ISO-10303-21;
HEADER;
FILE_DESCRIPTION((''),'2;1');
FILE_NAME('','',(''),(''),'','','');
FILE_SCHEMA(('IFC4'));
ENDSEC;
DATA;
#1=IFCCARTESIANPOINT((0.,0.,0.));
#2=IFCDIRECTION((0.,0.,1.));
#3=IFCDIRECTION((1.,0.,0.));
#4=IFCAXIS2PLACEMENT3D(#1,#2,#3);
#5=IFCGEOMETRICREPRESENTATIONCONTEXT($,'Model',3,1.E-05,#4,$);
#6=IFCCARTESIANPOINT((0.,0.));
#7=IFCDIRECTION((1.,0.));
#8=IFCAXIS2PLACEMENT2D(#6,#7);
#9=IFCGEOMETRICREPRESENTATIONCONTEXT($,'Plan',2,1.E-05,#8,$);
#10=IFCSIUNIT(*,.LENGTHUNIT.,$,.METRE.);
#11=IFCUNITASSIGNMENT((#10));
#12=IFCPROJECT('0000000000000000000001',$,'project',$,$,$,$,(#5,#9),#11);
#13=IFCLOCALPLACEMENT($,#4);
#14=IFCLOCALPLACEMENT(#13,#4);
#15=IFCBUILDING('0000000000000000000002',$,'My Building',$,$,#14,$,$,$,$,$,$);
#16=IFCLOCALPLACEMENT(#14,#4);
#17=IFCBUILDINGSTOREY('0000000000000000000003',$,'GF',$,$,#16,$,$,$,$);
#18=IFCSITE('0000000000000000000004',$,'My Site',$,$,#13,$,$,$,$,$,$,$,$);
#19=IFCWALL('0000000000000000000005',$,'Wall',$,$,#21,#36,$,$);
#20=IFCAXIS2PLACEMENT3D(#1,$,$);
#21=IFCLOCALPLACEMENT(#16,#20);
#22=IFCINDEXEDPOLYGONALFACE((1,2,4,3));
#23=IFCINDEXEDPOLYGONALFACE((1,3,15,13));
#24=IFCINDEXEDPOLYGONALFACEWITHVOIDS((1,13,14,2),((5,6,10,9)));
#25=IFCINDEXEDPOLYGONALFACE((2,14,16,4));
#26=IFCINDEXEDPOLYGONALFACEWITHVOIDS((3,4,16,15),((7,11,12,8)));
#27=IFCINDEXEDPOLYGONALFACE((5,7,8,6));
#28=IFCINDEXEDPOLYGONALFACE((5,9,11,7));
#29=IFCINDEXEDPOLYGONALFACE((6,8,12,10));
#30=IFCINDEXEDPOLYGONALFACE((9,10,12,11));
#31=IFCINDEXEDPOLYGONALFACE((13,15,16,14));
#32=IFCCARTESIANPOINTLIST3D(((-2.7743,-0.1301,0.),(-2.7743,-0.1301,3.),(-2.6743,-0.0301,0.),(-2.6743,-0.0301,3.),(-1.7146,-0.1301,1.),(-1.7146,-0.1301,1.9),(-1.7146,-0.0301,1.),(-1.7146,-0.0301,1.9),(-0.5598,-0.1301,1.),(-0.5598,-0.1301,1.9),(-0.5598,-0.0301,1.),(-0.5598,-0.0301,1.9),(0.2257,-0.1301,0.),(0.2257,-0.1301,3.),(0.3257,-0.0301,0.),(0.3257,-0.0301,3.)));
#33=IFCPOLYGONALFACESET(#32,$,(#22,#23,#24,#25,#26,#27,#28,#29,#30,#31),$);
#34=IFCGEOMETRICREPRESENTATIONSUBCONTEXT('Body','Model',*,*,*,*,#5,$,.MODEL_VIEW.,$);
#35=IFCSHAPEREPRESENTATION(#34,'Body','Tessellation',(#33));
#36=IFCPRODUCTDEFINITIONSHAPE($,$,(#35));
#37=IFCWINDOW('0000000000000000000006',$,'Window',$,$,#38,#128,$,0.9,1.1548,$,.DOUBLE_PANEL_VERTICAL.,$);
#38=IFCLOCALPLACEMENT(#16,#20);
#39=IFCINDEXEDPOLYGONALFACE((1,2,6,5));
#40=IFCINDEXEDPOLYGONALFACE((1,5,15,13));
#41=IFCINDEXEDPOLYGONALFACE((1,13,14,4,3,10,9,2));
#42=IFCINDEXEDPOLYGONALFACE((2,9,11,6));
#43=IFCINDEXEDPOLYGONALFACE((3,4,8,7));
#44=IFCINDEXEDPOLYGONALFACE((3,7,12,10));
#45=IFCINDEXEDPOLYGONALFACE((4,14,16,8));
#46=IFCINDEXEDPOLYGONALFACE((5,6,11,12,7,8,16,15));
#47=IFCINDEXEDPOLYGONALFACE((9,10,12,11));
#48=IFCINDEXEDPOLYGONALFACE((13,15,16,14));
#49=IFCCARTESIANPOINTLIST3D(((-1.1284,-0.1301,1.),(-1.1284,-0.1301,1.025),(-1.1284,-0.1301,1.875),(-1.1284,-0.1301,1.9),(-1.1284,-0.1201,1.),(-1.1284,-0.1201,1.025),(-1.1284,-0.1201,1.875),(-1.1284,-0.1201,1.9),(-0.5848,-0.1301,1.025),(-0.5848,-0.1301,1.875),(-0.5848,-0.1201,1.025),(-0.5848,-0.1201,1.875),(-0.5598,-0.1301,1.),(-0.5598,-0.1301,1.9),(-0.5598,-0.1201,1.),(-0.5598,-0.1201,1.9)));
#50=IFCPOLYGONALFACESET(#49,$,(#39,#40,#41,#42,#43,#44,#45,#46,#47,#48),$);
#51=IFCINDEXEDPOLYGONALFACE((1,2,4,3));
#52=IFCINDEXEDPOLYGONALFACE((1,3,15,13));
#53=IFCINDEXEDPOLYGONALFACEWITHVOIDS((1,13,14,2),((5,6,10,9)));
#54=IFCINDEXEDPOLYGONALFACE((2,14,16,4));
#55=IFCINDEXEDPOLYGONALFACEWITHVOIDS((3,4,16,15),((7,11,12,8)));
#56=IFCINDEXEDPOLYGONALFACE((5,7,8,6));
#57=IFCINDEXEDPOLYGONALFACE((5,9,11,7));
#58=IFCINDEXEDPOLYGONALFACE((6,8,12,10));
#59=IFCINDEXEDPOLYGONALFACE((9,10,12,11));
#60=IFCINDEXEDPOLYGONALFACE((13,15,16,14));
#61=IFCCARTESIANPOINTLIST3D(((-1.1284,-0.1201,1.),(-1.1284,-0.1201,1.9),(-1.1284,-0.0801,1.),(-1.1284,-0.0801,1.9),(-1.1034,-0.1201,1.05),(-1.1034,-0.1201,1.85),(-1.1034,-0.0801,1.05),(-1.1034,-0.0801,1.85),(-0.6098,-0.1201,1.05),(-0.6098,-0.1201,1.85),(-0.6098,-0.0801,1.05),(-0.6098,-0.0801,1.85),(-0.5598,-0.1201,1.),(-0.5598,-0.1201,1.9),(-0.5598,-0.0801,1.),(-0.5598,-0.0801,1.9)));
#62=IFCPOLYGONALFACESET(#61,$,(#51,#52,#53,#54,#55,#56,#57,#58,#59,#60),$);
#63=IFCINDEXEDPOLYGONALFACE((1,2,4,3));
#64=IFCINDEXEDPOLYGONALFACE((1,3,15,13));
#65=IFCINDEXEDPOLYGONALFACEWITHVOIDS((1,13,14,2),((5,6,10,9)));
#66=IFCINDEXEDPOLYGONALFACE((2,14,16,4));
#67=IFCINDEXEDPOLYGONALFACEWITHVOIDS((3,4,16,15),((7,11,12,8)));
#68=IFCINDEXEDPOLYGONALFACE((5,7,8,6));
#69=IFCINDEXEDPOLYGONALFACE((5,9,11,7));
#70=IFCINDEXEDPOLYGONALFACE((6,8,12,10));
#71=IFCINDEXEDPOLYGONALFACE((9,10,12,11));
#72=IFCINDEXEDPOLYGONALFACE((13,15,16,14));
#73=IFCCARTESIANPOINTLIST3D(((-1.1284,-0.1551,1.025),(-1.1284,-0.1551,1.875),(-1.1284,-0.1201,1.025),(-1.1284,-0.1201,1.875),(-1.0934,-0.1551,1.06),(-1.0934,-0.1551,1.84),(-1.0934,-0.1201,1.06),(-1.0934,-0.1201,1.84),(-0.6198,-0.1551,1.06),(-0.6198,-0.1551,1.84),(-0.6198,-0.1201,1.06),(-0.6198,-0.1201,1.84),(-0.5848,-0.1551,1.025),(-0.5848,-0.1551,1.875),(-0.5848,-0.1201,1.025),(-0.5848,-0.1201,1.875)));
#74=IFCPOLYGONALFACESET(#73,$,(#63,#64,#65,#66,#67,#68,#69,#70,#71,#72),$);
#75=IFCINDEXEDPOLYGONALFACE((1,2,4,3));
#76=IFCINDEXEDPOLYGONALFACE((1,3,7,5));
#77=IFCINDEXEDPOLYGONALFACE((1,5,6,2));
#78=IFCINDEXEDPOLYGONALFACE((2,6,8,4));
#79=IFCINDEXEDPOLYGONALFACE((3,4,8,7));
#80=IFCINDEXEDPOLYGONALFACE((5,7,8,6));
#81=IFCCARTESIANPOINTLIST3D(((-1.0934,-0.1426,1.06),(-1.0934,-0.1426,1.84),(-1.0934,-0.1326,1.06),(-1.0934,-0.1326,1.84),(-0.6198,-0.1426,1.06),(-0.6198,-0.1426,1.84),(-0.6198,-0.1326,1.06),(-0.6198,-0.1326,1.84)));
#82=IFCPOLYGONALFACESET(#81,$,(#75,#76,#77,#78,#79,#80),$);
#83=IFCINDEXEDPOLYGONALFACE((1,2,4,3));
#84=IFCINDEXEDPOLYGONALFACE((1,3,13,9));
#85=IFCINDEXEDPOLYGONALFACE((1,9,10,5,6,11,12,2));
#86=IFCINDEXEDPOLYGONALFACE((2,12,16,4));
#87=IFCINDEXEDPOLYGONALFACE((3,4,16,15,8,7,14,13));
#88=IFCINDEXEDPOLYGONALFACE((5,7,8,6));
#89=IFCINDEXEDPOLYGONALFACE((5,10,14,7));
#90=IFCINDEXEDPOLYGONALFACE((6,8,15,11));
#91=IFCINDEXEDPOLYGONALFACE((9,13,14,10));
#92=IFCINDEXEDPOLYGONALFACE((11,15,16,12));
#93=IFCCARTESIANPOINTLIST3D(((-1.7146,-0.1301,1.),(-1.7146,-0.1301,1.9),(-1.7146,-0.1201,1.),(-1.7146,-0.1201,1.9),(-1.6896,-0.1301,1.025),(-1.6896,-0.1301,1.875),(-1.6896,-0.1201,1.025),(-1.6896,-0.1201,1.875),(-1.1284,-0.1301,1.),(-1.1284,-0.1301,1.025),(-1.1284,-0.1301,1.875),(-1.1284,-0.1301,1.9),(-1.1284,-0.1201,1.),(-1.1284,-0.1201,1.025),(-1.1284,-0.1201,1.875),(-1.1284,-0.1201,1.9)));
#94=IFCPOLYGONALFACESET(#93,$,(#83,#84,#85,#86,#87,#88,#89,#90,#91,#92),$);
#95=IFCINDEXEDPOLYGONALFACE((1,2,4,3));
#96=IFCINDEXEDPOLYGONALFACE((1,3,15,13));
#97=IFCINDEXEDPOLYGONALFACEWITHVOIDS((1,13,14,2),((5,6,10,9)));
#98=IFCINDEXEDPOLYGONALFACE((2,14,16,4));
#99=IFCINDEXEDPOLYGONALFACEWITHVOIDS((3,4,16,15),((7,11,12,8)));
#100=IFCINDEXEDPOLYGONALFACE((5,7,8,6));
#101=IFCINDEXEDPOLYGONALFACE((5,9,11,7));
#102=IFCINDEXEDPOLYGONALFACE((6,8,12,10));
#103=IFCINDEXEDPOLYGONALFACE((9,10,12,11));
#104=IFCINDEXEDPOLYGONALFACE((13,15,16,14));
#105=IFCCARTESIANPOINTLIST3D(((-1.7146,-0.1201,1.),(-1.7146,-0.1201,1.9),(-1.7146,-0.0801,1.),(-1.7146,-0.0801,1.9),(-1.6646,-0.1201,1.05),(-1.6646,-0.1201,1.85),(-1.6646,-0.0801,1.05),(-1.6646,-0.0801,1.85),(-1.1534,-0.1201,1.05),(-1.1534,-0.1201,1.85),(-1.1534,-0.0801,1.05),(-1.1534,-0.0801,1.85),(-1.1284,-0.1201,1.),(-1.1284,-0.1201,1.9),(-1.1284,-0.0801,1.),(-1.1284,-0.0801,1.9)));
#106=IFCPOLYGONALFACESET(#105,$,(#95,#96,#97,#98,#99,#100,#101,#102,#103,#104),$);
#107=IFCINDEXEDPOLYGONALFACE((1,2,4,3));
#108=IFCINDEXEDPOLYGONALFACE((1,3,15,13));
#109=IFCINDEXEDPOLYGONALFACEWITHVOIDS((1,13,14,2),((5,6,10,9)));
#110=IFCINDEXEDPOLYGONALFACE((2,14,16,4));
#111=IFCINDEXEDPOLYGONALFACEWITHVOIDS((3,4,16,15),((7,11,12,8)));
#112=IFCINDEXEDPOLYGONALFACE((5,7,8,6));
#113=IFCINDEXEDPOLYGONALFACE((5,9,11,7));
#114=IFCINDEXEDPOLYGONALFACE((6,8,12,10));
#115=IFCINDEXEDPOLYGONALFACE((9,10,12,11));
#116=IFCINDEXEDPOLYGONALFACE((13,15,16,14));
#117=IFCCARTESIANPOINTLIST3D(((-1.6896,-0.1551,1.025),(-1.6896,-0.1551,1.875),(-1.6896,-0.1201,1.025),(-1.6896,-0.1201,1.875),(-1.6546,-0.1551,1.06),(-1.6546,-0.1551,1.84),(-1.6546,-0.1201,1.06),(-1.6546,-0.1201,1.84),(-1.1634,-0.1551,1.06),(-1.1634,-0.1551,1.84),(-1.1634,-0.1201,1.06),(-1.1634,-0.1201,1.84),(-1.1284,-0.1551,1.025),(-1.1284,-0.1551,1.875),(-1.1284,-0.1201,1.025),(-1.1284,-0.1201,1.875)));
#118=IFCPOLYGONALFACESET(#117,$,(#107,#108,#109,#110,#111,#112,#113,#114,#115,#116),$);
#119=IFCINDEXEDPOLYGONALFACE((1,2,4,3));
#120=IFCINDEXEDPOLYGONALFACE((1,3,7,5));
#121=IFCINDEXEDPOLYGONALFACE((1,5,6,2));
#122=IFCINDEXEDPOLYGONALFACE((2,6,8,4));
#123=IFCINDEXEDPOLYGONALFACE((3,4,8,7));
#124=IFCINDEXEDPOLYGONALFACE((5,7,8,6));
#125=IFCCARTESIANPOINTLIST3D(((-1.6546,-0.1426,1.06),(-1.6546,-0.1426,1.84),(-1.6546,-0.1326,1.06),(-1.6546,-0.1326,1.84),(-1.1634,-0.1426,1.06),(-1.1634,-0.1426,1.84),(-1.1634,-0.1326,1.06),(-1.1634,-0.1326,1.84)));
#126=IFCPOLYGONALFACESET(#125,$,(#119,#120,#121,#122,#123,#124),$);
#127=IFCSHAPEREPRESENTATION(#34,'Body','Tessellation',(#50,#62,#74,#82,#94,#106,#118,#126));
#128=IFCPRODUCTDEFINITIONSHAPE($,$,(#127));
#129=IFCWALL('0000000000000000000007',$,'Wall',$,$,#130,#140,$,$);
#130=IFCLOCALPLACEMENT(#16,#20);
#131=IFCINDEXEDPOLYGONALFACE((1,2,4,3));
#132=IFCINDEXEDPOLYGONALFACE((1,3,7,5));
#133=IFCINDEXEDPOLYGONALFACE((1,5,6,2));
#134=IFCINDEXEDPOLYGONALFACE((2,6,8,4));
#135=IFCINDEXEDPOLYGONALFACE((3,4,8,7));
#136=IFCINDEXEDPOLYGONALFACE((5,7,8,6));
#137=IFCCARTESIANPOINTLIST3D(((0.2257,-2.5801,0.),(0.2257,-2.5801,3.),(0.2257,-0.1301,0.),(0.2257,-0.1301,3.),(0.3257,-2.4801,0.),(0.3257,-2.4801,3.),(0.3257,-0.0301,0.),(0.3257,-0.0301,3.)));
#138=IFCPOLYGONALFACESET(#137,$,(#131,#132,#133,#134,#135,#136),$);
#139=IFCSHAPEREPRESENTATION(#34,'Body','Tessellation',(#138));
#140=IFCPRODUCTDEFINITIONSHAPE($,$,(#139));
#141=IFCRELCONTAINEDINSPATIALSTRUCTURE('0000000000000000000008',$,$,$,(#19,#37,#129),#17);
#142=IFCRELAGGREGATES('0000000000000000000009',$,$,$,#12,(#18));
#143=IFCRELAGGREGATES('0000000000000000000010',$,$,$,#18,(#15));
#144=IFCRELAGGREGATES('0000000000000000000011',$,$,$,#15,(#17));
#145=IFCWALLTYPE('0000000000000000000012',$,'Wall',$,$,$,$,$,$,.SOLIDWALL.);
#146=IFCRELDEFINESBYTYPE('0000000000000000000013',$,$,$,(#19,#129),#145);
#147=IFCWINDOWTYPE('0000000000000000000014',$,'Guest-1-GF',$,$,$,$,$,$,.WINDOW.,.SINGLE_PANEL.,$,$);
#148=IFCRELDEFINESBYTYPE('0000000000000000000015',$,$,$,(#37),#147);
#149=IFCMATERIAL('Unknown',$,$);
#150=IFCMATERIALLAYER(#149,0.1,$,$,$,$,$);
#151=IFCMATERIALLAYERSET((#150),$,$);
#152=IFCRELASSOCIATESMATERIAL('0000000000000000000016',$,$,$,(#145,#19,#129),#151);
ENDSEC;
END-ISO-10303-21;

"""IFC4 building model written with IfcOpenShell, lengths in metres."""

from ifc_helpers import new_model, entity, si_unit, frame, origin_with_axes, origin_2d_with_axis, place, context, subcontext, project, spatial, line, indexed_curve, outline, extrude, shape, source, transform, mapped, material, layer, layer_set, layer_usage, type_object, type_shapes, element, fill, save


model = new_model("IFC4")

# Units and contexts
model_context = context("Model", 3, precision=1e-05, world=origin_with_axes())
plan_context = context("Plan", 2, precision=1e-05, world=origin_2d_with_axis())
body_context_1 = subcontext(model_context, "Body", "Model", "MODEL_VIEW")
body_context_2 = subcontext(plan_context, "Body", "Plan", "PLAN_VIEW")
ifc_project = project(units=[si_unit("LENGTHUNIT", "METRE")], contexts=[model_context, plan_context])

# Site, building, storey
site_placement = place(None, origin_with_axes())
site = spatial("IfcSite", under=ifc_project, at=site_placement, Name="My Site")
building_placement = place(site_placement, origin_with_axes())
building = spatial("IfcBuilding", under=site, at=building_placement, Name="My Building")
storey_placement = place(building_placement, origin_with_axes())
storey = spatial("IfcBuildingStorey", under=building, at=storey_placement, Name="GF")

# Shared definitions
ifc_material = material(Name="Unknown")

# Shared definitions
ifc_layer_1 = layer(ifc_material, 0.1)
ifc_layer_set_1 = layer_set([ifc_layer_1])
wall_type = type_object("IfcWallType", Name="Wall", PredefinedType="SOLIDWALL", material=ifc_layer_set_1)

# Wall, opening, window
ifc_layer_usage_1 = layer_usage(ifc_layer_set_1, "AXIS2", "POSITIVE", 0.0)
wall_1_placement = place(storey_placement, frame((-2.7743, -0.1301, 0.0), z_axis=(0.0, 0.0, 1.0), x_axis=(1.0, 0.0, 0.0)))
wall_1 = element("IfcWall", 1, at=wall_1_placement, inside=storey, type_object=wall_type, material=ifc_layer_usage_1, Name="Wall", context=body_context_1, shape_type="SweptSolid", body=[
    extrude(outline(indexed_curve([(0.0, 0.0), (0.1, 0.1), (3.1, 0.1), (3.0, 0.0)], segments=[line(1, 2, 3, 4, 1)])), origin_with_axes(), (0.0, 0.0, 1.0), 3.0),
])
shared_shape_1 = source(origin_with_axes(), body_context_1, "Body", "SweptSolid", [
    extrude(outline(indexed_curve([(0.0, 0.0), (1.1548, 0.0), (1.1548, 0.9), (0.0, 0.9)], segments=[line(1, 2, 3, 4, 1)])), frame((0.0, -0.6, 0.0), z_axis=(0.0, -1.0, 0.0), x_axis=(1.0, 0.0, 0.0)), (0.0, 0.0, -1.0), 1.2),
])
opening_1_placement = place(wall_1_placement, frame((2.2145, 0.1, 1.0), z_axis=(0.0, 0.0, 1.0), x_axis=(-1.0, 0.0, 0.0)))
opening_1 = element("IfcOpeningElement", 2, at=opening_1_placement, cuts=wall_1, PredefinedType="OPENING", context=body_context_1, shape_type="MappedRepresentation", body=[
    mapped(shared_shape_1, transform((0.0, 0.0, 0.0), x_axis=(1.0, 0.0, 0.0), y_axis=(0.0, 1.0, 0.0), z_axis=(0.0, 0.0, 1.0), scale=1.0)),
])
window_type_1 = type_object("IfcWindowType", Name="Guest-1-GF", PartitioningType="SINGLE_PANEL", PredefinedType="WINDOW")
shared_shape_2 = source(origin_with_axes(), body_context_1, "Body", "SweptSolid", [
    extrude(outline(indexed_curve([(0.5686, 0.0), (0.0, 0.0), (0.0, 0.9), (0.5686, 0.9), (0.5686, 0.875), (0.025, 0.875), (0.025, 0.025), (0.5686, 0.025)], segments=[line(1, 2, 3, 4, 5, 6, 7, 8, 1)])), frame((0.0, 0.09, 0.0), z_axis=(0.0, -1.0, 0.0), x_axis=(1.0, 0.0, 0.0)), (0.0, 0.0, -1.0), 0.01),
    extrude(outline(indexed_curve([(0.0, 0.0), (0.5686, 0.0), (0.5686, 0.9), (0.0, 0.9)], segments=[line(1, 2, 3, 4, 1)]), holes=[indexed_curve([(0.05, 0.05), (0.5436, 0.05), (0.5436, 0.85), (0.05, 0.85)], segments=[line(1, 2, 3, 4, 1)])]), frame((0.0, 0.05, 0.0), z_axis=(0.0, -1.0, 0.0), x_axis=(1.0, 0.0, 0.0)), (0.0, 0.0, -1.0), 0.04),
    extrude(outline(indexed_curve([(0.0, 0.0), (0.5436, 0.0), (0.5436, 0.85), (0.0, 0.85)], segments=[line(1, 2, 3, 4, 1)]), holes=[indexed_curve([(0.035, 0.035), (0.5086, 0.035), (0.5086, 0.815), (0.035, 0.815)], segments=[line(1, 2, 3, 4, 1)])]), frame((0.025, 0.09, 0.025), z_axis=(0.0, -1.0, 0.0), x_axis=(1.0, 0.0, 0.0)), (0.0, 0.0, -1.0), 0.035),
    extrude(outline(indexed_curve([(0.035, 0.035), (0.5086, 0.035), (0.5086, 0.815), (0.035, 0.815)], segments=[line(1, 2, 3, 4, 1)])), frame((0.025, 0.1025, 0.025), z_axis=(0.0, -1.0, 0.0), x_axis=(1.0, 0.0, 0.0)), (0.0, 0.0, -1.0), 0.01),
    extrude(outline(indexed_curve([(0.0, 0.9), (0.5862, 0.9), (0.5862, 0.0), (0.0, 0.0), (0.0, 0.025), (0.5612, 0.025), (0.5612, 0.875), (0.0, 0.875)], segments=[line(1, 2, 3, 4, 5, 6, 7, 8, 1)])), frame((0.5686, 0.09, 0.0), z_axis=(0.0, -1.0, 0.0), x_axis=(1.0, 0.0, 0.0)), (0.0, 0.0, -1.0), 0.01),
    extrude(outline(indexed_curve([(0.0, 0.0), (0.5862, 0.0), (0.5862, 0.9), (0.0, 0.9)], segments=[line(1, 2, 3, 4, 1)]), holes=[indexed_curve([(0.025, 0.05), (0.5362, 0.05), (0.5362, 0.85), (0.025, 0.85)], segments=[line(1, 2, 3, 4, 1)])]), frame((0.5686, 0.05, 0.0), z_axis=(0.0, -1.0, 0.0), x_axis=(1.0, 0.0, 0.0)), (0.0, 0.0, -1.0), 0.04),
    extrude(outline(indexed_curve([(0.0, 0.0), (0.5612, 0.0), (0.5612, 0.85), (0.0, 0.85)], segments=[line(1, 2, 3, 4, 1)]), holes=[indexed_curve([(0.035, 0.035), (0.5262, 0.035), (0.5262, 0.815), (0.035, 0.815)], segments=[line(1, 2, 3, 4, 1)])]), frame((0.5686, 0.09, 0.025), z_axis=(0.0, -1.0, 0.0), x_axis=(1.0, 0.0, 0.0)), (0.0, 0.0, -1.0), 0.035),
    extrude(outline(indexed_curve([(0.035, 0.035), (0.5262, 0.035), (0.5262, 0.815), (0.035, 0.815)], segments=[line(1, 2, 3, 4, 1)])), frame((0.5686, 0.1025, 0.025), z_axis=(0.0, -1.0, 0.0), x_axis=(1.0, 0.0, 0.0)), (0.0, 0.0, -1.0), 0.01),
])
shared_shape_3 = source(origin_with_axes(), body_context_2, "Body", "Curve2D", [
    entity("IfcIndexedPolyCurve", entity("IfcCartesianPointList2D", [[0.05, 0.05], [0.5436, 0.05]])),
    entity("IfcIndexedPolyCurve", entity("IfcCartesianPointList2D", [[0.0, 0.1], [0.025, 0.1], [0.025, 0.09], [0.05, 0.09], [0.05, 0.05], [0.0, 0.05]]), [entity("IfcLineIndex", [1, 2, 3, 4, 5, 6, 1])]),
    entity("IfcIndexedPolyCurve", entity("IfcCartesianPointList2D", [[0.5686, 0.1], [0.5686, 0.1], [0.5686, 0.09], [0.5436, 0.09], [0.5436, 0.05], [0.5686, 0.05]])),
    entity("IfcIndexedPolyCurve", entity("IfcCartesianPointList2D", [[0.025, 0.09], [0.06, 0.09], [0.06, 0.125], [0.025, 0.125]]), [entity("IfcLineIndex", [1, 2, 3, 4, 1])]),
    entity("IfcIndexedPolyCurve", entity("IfcCartesianPointList2D", [[0.5686, 0.09], [0.5336, 0.09], [0.5336, 0.125], [0.5686, 0.125]]), [entity("IfcLineIndex", [1, 2, 3, 4, 1])]),
    entity("IfcIndexedPolyCurve", entity("IfcCartesianPointList2D", [[0.06, 0.09], [0.5336, 0.09]])),
    entity("IfcIndexedPolyCurve", entity("IfcCartesianPointList2D", [[0.06, 0.125], [0.5336, 0.125]])),
    entity("IfcIndexedPolyCurve", entity("IfcCartesianPointList2D", [[0.06, 0.1075], [0.5336, 0.1075]])),
    entity("IfcIndexedPolyCurve", entity("IfcCartesianPointList2D", [[0.5936, 0.05], [1.1048, 0.05]])),
    entity("IfcIndexedPolyCurve", entity("IfcCartesianPointList2D", [[0.5686, 0.1], [0.5686, 0.1], [0.5686, 0.09], [0.5936, 0.09], [0.5936, 0.05], [0.5686, 0.05]])),
    entity("IfcIndexedPolyCurve", entity("IfcCartesianPointList2D", [[1.1548, 0.1], [1.1298, 0.1], [1.1298, 0.09], [1.1048, 0.09], [1.1048, 0.05], [1.1548, 0.05]]), [entity("IfcLineIndex", [1, 2, 3, 4, 5, 6, 1])]),
    entity("IfcIndexedPolyCurve", entity("IfcCartesianPointList2D", [[0.5686, 0.09], [0.6036, 0.09], [0.6036, 0.125], [0.5686, 0.125]]), [entity("IfcLineIndex", [1, 2, 3, 4, 1])]),
    entity("IfcIndexedPolyCurve", entity("IfcCartesianPointList2D", [[1.1298, 0.09], [1.0948, 0.09], [1.0948, 0.125], [1.1298, 0.125]]), [entity("IfcLineIndex", [1, 2, 3, 4, 1])]),
    entity("IfcIndexedPolyCurve", entity("IfcCartesianPointList2D", [[0.6036, 0.09], [1.0948, 0.09]])),
    entity("IfcIndexedPolyCurve", entity("IfcCartesianPointList2D", [[0.6036, 0.125], [1.0948, 0.125]])),
    entity("IfcIndexedPolyCurve", entity("IfcCartesianPointList2D", [[0.6036, 0.1075], [1.0948, 0.1075]])),
])
type_shapes(window_type_1, [shared_shape_2, shared_shape_3])
window_1_placement = place(opening_1_placement, frame((0.0, 0.0, 0.0), z_axis=(0.0, 0.0, 1.0), x_axis=(1.0, 0.0, 0.0)))
window_1 = element("IfcWindow", 3, at=window_1_placement, inside=storey, type_object=window_type_1, Name="Window", OverallHeight=0.9, OverallWidth=1.1548, PartitioningType="DOUBLE_PANEL_VERTICAL", shapes=[
    shape(body_context_1, "Body", "MappedRepresentation", [mapped(shared_shape_2, transform((0.0, 0.0, 0.0), x_axis=(1.0, 0.0, 0.0), y_axis=(0.0, 1.0, 0.0), z_axis=(0.0, 0.0, 1.0), scale=1.0))]),
    shape(body_context_2, "Body", "MappedRepresentation", [mapped(shared_shape_3, transform((0.0, 0.0, 0.0), x_axis=(1.0, 0.0, 0.0), y_axis=(0.0, 1.0, 0.0), z_axis=(0.0, 0.0, 1.0), scale=1.0))]),
])
fill(opening_1, window_1)

# Wall
ifc_layer_usage_2 = layer_usage(ifc_layer_set_1, "AXIS2", "POSITIVE", 0.0)
wall_2_placement = place(storey_placement, frame((0.2257, -0.1301, 0.0), z_axis=(0.0, 0.0, 1.0), x_axis=(-0.000001, -1.0, 0.0)))
element("IfcWall", 4, at=wall_2_placement, inside=storey, type_object=wall_type, material=ifc_layer_usage_2, Name="Wall", context=body_context_1, shape_type="SweptSolid", body=[
    extrude(outline(indexed_curve([(0.0, 0.0), (-0.1, 0.1), (2.35, 0.1), (2.45, 0.0)], segments=[line(1, 2, 3, 4, 1)])), origin_with_axes(), (0.0, 0.0, 1.0), 3.0),
])

save(model, "model.ifc")
